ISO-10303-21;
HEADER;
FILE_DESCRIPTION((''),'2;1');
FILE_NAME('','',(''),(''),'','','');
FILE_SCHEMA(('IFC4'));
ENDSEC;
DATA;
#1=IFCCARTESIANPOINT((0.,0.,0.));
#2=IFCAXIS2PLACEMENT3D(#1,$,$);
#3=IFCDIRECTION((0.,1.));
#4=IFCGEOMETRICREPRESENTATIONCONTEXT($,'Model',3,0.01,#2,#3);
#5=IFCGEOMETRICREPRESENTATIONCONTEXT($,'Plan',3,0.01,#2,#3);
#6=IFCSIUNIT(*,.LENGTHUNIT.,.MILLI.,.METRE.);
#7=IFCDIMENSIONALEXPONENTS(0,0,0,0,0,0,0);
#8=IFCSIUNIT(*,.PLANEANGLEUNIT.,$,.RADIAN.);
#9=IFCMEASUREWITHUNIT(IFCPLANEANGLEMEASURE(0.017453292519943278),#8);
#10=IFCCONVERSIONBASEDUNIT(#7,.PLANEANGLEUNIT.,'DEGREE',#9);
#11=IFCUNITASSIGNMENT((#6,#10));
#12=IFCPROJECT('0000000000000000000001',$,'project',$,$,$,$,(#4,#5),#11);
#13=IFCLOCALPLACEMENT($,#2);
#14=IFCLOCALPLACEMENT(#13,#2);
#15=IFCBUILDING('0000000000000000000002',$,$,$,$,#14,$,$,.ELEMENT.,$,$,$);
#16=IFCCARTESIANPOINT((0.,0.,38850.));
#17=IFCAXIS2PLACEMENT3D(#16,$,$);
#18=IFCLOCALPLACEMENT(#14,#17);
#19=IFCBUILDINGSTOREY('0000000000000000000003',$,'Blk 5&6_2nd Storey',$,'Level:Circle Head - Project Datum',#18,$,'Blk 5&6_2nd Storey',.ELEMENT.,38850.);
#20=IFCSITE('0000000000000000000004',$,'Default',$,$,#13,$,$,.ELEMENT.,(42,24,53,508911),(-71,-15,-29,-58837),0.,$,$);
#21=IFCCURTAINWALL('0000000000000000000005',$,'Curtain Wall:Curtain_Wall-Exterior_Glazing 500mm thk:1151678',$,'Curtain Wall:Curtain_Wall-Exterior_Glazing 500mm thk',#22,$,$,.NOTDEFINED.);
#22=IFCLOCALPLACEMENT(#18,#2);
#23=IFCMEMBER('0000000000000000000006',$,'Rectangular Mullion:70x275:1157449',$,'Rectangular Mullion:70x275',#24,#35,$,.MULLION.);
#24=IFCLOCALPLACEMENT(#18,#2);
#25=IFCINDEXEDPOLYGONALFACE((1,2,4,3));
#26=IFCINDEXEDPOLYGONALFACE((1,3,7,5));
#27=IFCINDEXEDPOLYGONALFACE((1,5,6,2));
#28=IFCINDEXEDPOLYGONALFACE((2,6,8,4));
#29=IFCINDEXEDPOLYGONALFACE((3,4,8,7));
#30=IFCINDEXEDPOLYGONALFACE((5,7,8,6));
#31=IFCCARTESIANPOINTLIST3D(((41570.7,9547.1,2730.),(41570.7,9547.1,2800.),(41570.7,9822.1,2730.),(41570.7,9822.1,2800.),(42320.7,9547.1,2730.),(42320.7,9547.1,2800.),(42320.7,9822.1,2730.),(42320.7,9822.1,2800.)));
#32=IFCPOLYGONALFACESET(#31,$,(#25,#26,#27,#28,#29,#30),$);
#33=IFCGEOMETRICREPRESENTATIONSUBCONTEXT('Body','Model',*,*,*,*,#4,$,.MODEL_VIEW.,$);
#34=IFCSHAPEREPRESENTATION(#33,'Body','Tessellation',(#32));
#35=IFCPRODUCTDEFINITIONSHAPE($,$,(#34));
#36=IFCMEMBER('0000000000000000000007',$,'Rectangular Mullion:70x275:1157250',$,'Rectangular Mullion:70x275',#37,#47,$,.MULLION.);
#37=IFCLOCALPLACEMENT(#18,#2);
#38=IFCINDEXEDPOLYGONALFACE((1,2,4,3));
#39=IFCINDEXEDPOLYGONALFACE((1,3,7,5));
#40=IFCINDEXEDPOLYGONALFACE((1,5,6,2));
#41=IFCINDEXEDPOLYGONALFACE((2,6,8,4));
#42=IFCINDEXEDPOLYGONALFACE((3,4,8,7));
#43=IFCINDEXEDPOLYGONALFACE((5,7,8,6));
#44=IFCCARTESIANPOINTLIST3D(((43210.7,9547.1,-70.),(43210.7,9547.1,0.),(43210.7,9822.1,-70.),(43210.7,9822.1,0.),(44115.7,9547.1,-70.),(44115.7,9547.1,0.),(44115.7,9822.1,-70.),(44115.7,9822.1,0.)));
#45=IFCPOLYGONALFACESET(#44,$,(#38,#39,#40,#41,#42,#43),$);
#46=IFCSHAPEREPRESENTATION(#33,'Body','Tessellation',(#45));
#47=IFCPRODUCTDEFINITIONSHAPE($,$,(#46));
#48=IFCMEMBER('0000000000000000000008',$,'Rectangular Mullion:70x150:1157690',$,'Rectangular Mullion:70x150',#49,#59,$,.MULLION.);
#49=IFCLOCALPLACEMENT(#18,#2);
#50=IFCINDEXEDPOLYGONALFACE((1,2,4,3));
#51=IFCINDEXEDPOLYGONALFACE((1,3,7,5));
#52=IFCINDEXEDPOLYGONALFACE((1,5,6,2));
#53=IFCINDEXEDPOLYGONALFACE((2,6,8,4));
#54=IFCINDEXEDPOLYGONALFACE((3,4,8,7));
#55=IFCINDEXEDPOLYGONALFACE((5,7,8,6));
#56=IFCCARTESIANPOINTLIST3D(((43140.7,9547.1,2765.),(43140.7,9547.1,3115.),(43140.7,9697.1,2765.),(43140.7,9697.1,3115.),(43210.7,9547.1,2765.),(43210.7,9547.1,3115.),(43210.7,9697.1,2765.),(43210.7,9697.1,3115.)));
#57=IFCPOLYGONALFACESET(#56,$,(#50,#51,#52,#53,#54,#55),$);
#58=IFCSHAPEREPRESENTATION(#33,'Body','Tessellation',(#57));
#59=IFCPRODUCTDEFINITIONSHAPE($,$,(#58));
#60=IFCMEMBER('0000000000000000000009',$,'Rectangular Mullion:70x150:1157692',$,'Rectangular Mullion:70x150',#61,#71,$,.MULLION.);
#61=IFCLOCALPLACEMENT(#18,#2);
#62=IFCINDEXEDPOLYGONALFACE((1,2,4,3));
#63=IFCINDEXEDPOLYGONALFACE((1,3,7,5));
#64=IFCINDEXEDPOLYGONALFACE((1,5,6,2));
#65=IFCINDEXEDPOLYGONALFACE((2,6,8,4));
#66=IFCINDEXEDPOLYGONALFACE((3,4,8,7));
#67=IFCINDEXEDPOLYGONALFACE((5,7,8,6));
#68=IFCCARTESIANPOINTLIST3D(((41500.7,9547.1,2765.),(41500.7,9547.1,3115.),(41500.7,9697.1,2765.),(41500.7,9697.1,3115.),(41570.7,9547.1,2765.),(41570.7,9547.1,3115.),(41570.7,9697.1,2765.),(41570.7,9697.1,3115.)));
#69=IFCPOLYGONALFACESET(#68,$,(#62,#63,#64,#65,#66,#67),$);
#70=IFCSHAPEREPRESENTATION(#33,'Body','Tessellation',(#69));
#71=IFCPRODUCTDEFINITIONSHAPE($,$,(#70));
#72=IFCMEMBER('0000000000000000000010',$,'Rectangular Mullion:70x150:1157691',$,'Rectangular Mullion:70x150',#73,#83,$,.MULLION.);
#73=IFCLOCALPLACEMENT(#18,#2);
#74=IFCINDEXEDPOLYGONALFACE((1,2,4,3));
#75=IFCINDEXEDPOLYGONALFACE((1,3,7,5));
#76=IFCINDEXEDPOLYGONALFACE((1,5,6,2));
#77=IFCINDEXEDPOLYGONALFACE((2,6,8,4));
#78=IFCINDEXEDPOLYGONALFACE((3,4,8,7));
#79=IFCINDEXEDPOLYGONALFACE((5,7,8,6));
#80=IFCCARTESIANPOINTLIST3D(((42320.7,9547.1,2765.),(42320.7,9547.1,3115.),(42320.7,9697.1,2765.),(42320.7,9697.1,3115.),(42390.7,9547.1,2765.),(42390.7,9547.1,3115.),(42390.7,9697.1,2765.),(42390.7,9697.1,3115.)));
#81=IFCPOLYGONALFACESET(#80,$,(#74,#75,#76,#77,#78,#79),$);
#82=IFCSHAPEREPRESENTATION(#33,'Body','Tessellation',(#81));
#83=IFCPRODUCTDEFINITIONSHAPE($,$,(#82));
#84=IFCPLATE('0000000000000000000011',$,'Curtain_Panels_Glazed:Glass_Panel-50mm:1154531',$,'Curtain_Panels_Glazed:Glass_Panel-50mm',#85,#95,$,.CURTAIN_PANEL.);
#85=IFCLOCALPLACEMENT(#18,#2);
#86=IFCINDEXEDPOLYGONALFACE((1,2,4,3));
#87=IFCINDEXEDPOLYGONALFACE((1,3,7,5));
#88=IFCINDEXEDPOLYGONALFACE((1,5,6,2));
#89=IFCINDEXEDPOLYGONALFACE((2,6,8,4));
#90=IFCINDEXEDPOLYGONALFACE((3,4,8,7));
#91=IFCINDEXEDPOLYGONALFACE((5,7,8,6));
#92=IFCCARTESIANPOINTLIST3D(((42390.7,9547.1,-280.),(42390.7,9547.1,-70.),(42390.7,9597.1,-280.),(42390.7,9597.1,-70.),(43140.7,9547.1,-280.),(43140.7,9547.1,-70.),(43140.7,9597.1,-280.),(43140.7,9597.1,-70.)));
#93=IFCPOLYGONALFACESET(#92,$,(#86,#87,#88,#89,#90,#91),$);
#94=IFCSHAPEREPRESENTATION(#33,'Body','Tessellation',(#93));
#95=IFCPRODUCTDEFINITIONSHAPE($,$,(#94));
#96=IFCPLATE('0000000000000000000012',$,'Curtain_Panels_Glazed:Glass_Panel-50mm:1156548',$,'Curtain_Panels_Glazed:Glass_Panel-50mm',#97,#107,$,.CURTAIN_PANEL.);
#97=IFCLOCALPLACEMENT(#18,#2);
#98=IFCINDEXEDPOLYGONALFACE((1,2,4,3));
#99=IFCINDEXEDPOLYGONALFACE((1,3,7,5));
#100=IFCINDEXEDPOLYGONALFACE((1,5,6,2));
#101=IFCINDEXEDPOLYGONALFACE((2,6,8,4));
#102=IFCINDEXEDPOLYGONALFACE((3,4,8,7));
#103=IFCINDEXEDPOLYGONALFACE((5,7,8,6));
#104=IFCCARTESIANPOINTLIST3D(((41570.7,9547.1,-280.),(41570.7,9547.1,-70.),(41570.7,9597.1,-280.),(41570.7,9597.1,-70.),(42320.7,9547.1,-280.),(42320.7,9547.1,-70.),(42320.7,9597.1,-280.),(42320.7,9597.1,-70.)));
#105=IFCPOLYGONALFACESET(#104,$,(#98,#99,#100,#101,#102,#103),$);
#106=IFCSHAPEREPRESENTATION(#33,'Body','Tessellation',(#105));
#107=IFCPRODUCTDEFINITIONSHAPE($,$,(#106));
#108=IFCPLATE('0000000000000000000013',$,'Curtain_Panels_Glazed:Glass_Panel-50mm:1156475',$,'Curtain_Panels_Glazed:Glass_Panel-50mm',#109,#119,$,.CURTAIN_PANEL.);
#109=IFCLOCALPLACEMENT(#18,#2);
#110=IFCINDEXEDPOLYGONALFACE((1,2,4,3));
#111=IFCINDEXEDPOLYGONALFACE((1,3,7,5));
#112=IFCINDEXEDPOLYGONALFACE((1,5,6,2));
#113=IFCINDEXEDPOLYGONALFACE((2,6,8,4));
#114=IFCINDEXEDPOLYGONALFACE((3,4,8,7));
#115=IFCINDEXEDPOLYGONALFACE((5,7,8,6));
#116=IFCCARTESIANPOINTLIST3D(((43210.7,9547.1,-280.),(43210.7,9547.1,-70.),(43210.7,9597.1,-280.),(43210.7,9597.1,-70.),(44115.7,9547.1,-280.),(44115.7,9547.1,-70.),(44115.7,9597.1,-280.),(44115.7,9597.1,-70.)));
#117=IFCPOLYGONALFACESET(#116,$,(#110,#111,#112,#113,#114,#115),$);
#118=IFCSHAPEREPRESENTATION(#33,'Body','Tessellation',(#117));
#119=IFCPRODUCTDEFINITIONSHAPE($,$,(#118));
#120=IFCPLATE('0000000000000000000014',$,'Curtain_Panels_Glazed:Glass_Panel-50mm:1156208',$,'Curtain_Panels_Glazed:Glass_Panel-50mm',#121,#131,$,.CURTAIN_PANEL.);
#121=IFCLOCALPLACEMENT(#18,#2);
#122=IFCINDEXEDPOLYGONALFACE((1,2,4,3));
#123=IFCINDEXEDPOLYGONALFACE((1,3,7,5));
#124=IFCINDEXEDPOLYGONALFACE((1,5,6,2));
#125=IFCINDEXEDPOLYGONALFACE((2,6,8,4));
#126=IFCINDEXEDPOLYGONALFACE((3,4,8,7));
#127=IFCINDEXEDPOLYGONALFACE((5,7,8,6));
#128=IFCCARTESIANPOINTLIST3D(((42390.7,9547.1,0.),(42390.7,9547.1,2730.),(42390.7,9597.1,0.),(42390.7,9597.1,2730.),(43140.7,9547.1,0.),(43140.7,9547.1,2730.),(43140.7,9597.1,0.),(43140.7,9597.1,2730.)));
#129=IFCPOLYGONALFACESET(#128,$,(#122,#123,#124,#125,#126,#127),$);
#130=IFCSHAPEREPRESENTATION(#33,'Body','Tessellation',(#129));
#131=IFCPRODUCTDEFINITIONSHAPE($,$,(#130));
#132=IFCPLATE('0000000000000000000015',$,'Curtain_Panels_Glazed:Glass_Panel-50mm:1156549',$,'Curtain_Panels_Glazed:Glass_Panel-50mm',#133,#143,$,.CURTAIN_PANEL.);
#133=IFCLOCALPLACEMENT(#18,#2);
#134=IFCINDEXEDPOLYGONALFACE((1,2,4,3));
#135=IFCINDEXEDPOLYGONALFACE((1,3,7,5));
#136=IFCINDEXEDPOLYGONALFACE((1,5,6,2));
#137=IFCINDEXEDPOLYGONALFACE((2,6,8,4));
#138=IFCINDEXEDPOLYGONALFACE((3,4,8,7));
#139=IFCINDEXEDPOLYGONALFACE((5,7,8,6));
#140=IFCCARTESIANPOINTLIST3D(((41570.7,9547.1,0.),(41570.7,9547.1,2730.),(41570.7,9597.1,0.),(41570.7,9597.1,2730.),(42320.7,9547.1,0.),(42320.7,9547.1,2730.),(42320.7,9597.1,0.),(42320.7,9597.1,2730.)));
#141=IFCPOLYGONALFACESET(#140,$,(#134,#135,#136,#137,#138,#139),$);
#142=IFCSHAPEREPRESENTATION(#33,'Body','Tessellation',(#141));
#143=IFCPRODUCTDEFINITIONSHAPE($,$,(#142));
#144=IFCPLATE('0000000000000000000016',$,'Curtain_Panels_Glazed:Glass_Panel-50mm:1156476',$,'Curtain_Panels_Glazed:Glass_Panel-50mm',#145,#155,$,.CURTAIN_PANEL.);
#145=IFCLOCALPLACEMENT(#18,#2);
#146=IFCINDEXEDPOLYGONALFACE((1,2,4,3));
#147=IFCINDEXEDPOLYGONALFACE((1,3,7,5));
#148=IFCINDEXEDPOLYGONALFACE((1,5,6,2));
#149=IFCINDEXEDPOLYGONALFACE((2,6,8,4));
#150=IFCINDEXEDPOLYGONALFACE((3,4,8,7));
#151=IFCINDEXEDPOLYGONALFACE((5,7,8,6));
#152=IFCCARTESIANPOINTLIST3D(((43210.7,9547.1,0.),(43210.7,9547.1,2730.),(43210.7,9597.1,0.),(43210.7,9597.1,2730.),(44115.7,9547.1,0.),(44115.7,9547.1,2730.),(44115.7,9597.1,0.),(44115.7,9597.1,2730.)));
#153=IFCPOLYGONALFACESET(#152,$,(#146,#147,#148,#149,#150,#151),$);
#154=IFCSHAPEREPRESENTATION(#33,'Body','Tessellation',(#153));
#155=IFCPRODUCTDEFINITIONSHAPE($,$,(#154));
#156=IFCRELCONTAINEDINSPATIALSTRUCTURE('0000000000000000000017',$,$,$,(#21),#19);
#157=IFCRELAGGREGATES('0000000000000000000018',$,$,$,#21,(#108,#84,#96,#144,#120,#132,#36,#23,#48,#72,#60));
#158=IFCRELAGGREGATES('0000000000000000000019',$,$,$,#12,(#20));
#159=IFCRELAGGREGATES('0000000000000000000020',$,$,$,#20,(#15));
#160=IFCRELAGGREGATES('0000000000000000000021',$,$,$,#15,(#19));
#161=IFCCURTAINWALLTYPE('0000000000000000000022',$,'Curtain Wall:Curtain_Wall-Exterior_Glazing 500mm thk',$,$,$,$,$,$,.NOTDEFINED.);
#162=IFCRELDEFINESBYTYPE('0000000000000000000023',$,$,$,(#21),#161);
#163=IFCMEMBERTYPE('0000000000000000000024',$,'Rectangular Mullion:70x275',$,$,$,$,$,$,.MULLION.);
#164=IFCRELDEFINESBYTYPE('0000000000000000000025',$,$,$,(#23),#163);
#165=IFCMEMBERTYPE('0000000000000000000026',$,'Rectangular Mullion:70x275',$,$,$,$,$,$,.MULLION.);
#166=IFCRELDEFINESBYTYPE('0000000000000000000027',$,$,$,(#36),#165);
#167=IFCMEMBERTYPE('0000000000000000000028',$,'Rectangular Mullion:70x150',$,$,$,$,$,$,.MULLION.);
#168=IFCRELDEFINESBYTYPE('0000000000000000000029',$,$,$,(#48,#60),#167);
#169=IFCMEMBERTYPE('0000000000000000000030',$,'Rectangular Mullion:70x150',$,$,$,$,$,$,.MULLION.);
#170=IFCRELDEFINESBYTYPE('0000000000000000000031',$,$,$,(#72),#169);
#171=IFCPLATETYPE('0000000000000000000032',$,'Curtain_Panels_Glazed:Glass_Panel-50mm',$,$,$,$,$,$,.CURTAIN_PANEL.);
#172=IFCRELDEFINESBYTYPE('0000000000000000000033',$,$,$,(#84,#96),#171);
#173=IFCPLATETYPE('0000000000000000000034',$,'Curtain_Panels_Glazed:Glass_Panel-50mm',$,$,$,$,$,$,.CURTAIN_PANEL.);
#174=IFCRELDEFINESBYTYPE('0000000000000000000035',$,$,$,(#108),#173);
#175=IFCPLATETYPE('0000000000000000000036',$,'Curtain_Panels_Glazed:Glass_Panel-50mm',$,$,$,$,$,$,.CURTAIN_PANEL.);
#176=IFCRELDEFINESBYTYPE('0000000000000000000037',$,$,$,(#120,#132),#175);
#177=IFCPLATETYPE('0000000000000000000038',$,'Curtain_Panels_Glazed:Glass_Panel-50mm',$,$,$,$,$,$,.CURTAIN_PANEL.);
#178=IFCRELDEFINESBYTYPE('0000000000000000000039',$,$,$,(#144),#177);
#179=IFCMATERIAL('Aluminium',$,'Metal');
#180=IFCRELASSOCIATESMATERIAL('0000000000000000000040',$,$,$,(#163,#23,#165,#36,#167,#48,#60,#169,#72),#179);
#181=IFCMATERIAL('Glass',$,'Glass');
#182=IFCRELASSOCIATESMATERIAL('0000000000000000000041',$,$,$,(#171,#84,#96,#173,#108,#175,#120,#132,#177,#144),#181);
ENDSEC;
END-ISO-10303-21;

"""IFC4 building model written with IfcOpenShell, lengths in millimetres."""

from ifc_helpers import new_model, entity, si_unit, converted_unit, direction, frame, origin, place, context, subcontext, project, spatial, indexed_curve, outline, extrude, source, transform, mapped, material, type_object, type_shapes, element, aggregate, save


model = new_model("IFC4")

# Units and contexts
model_context = context("Model", 3, precision=0.01, world=origin(), true_north=direction((0.0, 1.0)))
plan_context = context("Plan", 3, precision=0.01, world=origin(), true_north=direction((0.0, 1.0)))
body_context = subcontext(model_context, "Body", "Model", "MODEL_VIEW")
ifc_project = project(units=[si_unit("LENGTHUNIT", "METRE", prefix="MILLI"), converted_unit("PLANEANGLEUNIT", "DEGREE", entity("IfcPlaneAngleMeasure", 0.017453292519943278), si_unit("PLANEANGLEUNIT", "RADIAN"), dimensions=[0, 0, 0, 0, 0, 0, 0])], contexts=[model_context, plan_context])

# Site, building, storey
site_placement = place(None, origin())
site = spatial("IfcSite", under=ifc_project, at=site_placement, Name="Default", CompositionType="ELEMENT", RefLatitude=(42, 24, 53, 508911), RefLongitude=(-71, -15, -29, -58837), RefElevation=0.0)
building_placement = place(site_placement, origin())
building = spatial("IfcBuilding", under=site, at=building_placement, CompositionType="ELEMENT")
storey_placement = place(building_placement, frame((0.0, 0.0, 38850.0)))
storey = spatial("IfcBuildingStorey", under=building, at=storey_placement, Name="Blk 5&6_2nd Storey", ObjectType="Level:Circle Head - Project Datum", LongName="Blk 5&6_2nd Storey", CompositionType="ELEMENT", Elevation=38850.0)

# Curtain wall, members, plates
curtain_wall_type = type_object("IfcCurtainWallType", Name="Curtain Wall:Curtain_Wall-Exterior_Glazing 500mm thk", PredefinedType="NOTDEFINED")
curtain_wall_placement = place(storey_placement, frame((0.0, 0.0, -38850.0)))
curtain_wall = element("IfcCurtainWall", 1, at=curtain_wall_placement, inside=storey, type_object=curtain_wall_type, Name="Curtain Wall:Curtain_Wall-Exterior_Glazing 500mm thk:1151678", ObjectType="Curtain Wall:Curtain_Wall-Exterior_Glazing 500mm thk", PredefinedType="NOTDEFINED")
ifc_material_1 = material(Name="Aluminium", Category="Metal")
member_type_1 = type_object("IfcMemberType", Name="Rectangular Mullion:70x275", PredefinedType="MULLION", material=ifc_material_1)
shared_shape_1 = source(origin(), body_context, "Body", "SweptSolid", [
    extrude(outline(indexed_curve([(-35.0, -137.5), (35.0, -137.5), (35.0, 137.5), (-35.0, 137.5), (-35.0, -137.5)], self_intersect=False)), frame((0.0, -137.5, -750.0), z_axis=(0.0, 0.0, 1.0), x_axis=(-1.0, 0.0, 0.0)), (0.0, 0.0, 1.0), 750.0),
])
type_shapes(member_type_1, [shared_shape_1])
member_1_placement = place(curtain_wall_placement, frame((41570.7, 9822.1, 41615.0), z_axis=(-1.0, 0.0, 0.0), x_axis=(0.0, 0.0, 1.0)))
member_1 = element("IfcMember", 2, at=member_1_placement, type_object=member_type_1, material=ifc_material_1, Name="Rectangular Mullion:70x275:1157449", ObjectType="Rectangular Mullion:70x275", PredefinedType="MULLION", context=body_context, shape_type="MappedRepresentation", body=[
    mapped(shared_shape_1, transform((0.0, 0.0, 0.0), scale=1.0)),
])
member_type_2 = type_object("IfcMemberType", Name="Rectangular Mullion:70x275", PredefinedType="MULLION", material=ifc_material_1)
shared_shape_2 = source(origin(), body_context, "Body", "SweptSolid", [
    extrude(outline(indexed_curve([(-35.0, -137.5), (35.0, -137.5), (35.0, 137.5), (-35.0, 137.5), (-35.0, -137.5)], self_intersect=False)), frame((0.0, -137.5, -905.0), z_axis=(0.0, 0.0, 1.0), x_axis=(-1.0, 0.0, 0.0)), (0.0, 0.0, 1.0), 905.0),
])
type_shapes(member_type_2, [shared_shape_2])
member_2_placement = place(curtain_wall_placement, frame((43210.7, 9822.1, 38815.0), z_axis=(-1.0, 0.0, 0.0), x_axis=(0.0, 0.0, 1.0)))
member_2 = element("IfcMember", 3, at=member_2_placement, type_object=member_type_2, material=ifc_material_1, Name="Rectangular Mullion:70x275:1157250", ObjectType="Rectangular Mullion:70x275", PredefinedType="MULLION", context=body_context, shape_type="MappedRepresentation", body=[
    mapped(shared_shape_2, transform((0.0, 0.0, 0.0), scale=1.0)),
])
member_type_3 = type_object("IfcMemberType", Name="Rectangular Mullion:70x150", PredefinedType="MULLION", material=ifc_material_1)
shared_shape_3 = source(origin(), body_context, "Body", "SweptSolid", [
    extrude(outline(indexed_curve([(-35.0, -75.0), (35.0, -75.0), (35.0, 75.0), (-35.0, 75.0), (-35.0, -75.0)], self_intersect=False)), frame((0.0, -200.0, -350.0), z_axis=(0.0, 0.0, 1.0), x_axis=(-1.0, 0.0, 0.0)), (0.0, 0.0, 1.0), 350.0),
])
type_shapes(member_type_3, [shared_shape_3])
member_3_placement = place(curtain_wall_placement, frame((43175.7, 9822.1, 41615.0), z_axis=(0.0, 0.0, -1.0), x_axis=(-1.0, 0.0, 0.0)))
member_3 = element("IfcMember", 4, at=member_3_placement, type_object=member_type_3, material=ifc_material_1, Name="Rectangular Mullion:70x150:1157690", ObjectType="Rectangular Mullion:70x150", PredefinedType="MULLION", context=body_context, shape_type="MappedRepresentation", body=[
    mapped(shared_shape_3, transform((0.0, 0.0, 0.0), scale=1.0)),
])
member_4_placement = place(curtain_wall_placement, frame((41535.7, 9822.1, 41615.0), z_axis=(0.0, 0.0, -1.0), x_axis=(-1.0, 0.0, 0.0)))
member_4 = element("IfcMember", 5, at=member_4_placement, type_object=member_type_3, material=ifc_material_1, Name="Rectangular Mullion:70x150:1157692", ObjectType="Rectangular Mullion:70x150", PredefinedType="MULLION", context=body_context, shape_type="MappedRepresentation", body=[
    mapped(shared_shape_3, transform((0.0, 0.0, 0.0), scale=1.0)),
])
member_type_4 = type_object("IfcMemberType", Name="Rectangular Mullion:70x150", PredefinedType="MULLION", material=ifc_material_1)
shared_shape_4 = source(origin(), body_context, "Body", "SweptSolid", [
    extrude(outline(indexed_curve([(-35.0, -75.0), (35.0, -75.0), (35.0, 75.0), (-35.0, 75.0), (-35.0, -75.0)], self_intersect=False)), frame((0.0, -200.0, -350.0), z_axis=(0.0, 0.0, 1.0), x_axis=(-1.0, 0.0, 0.0)), (0.0, 0.0, 1.0), 350.0),
])
type_shapes(member_type_4, [shared_shape_4])
member_5_placement = place(curtain_wall_placement, frame((42355.7, 9822.1, 41615.0), z_axis=(0.0, 0.0, -1.0), x_axis=(-1.0, 0.0, 0.0)))
member_5 = element("IfcMember", 6, at=member_5_placement, type_object=member_type_4, material=ifc_material_1, Name="Rectangular Mullion:70x150:1157691", ObjectType="Rectangular Mullion:70x150", PredefinedType="MULLION", context=body_context, shape_type="MappedRepresentation", body=[
    mapped(shared_shape_4, transform((0.0, 0.0, 0.0), scale=1.0)),
])
ifc_material_2 = material(Name="Glass", Category="Glass")
plate_type_1 = type_object("IfcPlateType", Name="Curtain_Panels_Glazed:Glass_Panel-50mm", PredefinedType="CURTAIN_PANEL", material=ifc_material_2)
shared_shape_5 = source(origin(), body_context, "Body", "SweptSolid", [
    extrude(outline(indexed_curve([(-25.0, -375.0), (25.0, -375.0), (25.0, 375.0), (-25.0, 375.0), (-25.0, -375.0)], self_intersect=False)), frame((0.0, 250.0, 0.0), z_axis=(0.0, 0.0, 1.0), x_axis=(0.0, 1.0, 0.0)), (0.0, 0.0, 1.0), 210.0),
])
type_shapes(plate_type_1, [shared_shape_5])
plate_1_placement = place(curtain_wall_placement, frame((42765.7, 9822.1, 38570.0), z_axis=(0.0, 0.0, 1.0), x_axis=(-1.0, 0.0, 0.0)))
plate_1 = element("IfcPlate", 7, at=plate_1_placement, type_object=plate_type_1, material=ifc_material_2, Name="Curtain_Panels_Glazed:Glass_Panel-50mm:1154531", ObjectType="Curtain_Panels_Glazed:Glass_Panel-50mm", PredefinedType="CURTAIN_PANEL", context=body_context, shape_type="MappedRepresentation", body=[
    mapped(shared_shape_5, transform((0.0, 0.0, 0.0), scale=1.0)),
])
plate_2_placement = place(curtain_wall_placement, frame((41945.7, 9822.1, 38570.0), z_axis=(0.0, 0.0, 1.0), x_axis=(-1.0, 0.0, 0.0)))
plate_2 = element("IfcPlate", 8, at=plate_2_placement, type_object=plate_type_1, material=ifc_material_2, Name="Curtain_Panels_Glazed:Glass_Panel-50mm:1156548", ObjectType="Curtain_Panels_Glazed:Glass_Panel-50mm", PredefinedType="CURTAIN_PANEL", context=body_context, shape_type="MappedRepresentation", body=[
    mapped(shared_shape_5, transform((0.0, 0.0, 0.0), scale=1.0)),
])
plate_type_2 = type_object("IfcPlateType", Name="Curtain_Panels_Glazed:Glass_Panel-50mm", PredefinedType="CURTAIN_PANEL", material=ifc_material_2)
shared_shape_6 = source(origin(), body_context, "Body", "SweptSolid", [
    extrude(outline(indexed_curve([(-25.0, -452.5), (25.0, -452.5), (25.0, 452.5), (-25.0, 452.5), (-25.0, -452.5)], self_intersect=False)), frame((0.0, 250.0, 0.0), z_axis=(0.0, 0.0, 1.0), x_axis=(0.0, 1.0, 0.0)), (0.0, 0.0, 1.0), 210.0),
])
type_shapes(plate_type_2, [shared_shape_6])
plate_3_placement = place(curtain_wall_placement, frame((43663.2, 9822.1, 38570.0), z_axis=(0.0, 0.0, 1.0), x_axis=(-1.0, 0.0, 0.0)))
plate_3 = element("IfcPlate", 9, at=plate_3_placement, type_object=plate_type_2, material=ifc_material_2, Name="Curtain_Panels_Glazed:Glass_Panel-50mm:1156475", ObjectType="Curtain_Panels_Glazed:Glass_Panel-50mm", PredefinedType="CURTAIN_PANEL", context=body_context, shape_type="MappedRepresentation", body=[
    mapped(shared_shape_6, transform((0.0, 0.0, 0.0), scale=1.0)),
])
plate_type_3 = type_object("IfcPlateType", Name="Curtain_Panels_Glazed:Glass_Panel-50mm", PredefinedType="CURTAIN_PANEL", material=ifc_material_2)
shared_shape_7 = source(origin(), body_context, "Body", "SweptSolid", [
    extrude(outline(indexed_curve([(-25.0, -375.0), (25.0, -375.0), (25.0, 375.0), (-25.0, 375.0), (-25.0, -375.0)], self_intersect=False)), frame((0.0, 250.0, 0.0), z_axis=(0.0, 0.0, 1.0), x_axis=(0.0, 1.0, 0.0)), (0.0, 0.0, 1.0), 2730.0),
])
type_shapes(plate_type_3, [shared_shape_7])
plate_4_placement = place(curtain_wall_placement, frame((42765.7, 9822.1, 38850.0), z_axis=(0.0, 0.0, 1.0), x_axis=(-1.0, 0.0, 0.0)))
plate_4 = element("IfcPlate", 10, at=plate_4_placement, type_object=plate_type_3, material=ifc_material_2, Name="Curtain_Panels_Glazed:Glass_Panel-50mm:1156208", ObjectType="Curtain_Panels_Glazed:Glass_Panel-50mm", PredefinedType="CURTAIN_PANEL", context=body_context, shape_type="MappedRepresentation", body=[
    mapped(shared_shape_7, transform((0.0, 0.0, 0.0), scale=1.0)),
])
plate_5_placement = place(curtain_wall_placement, frame((41945.7, 9822.1, 38850.0), z_axis=(0.0, 0.0, 1.0), x_axis=(-1.0, 0.0, 0.0)))
plate_5 = element("IfcPlate", 11, at=plate_5_placement, type_object=plate_type_3, material=ifc_material_2, Name="Curtain_Panels_Glazed:Glass_Panel-50mm:1156549", ObjectType="Curtain_Panels_Glazed:Glass_Panel-50mm", PredefinedType="CURTAIN_PANEL", context=body_context, shape_type="MappedRepresentation", body=[
    mapped(shared_shape_7, transform((0.0, 0.0, 0.0), scale=1.0)),
])
plate_type_4 = type_object("IfcPlateType", Name="Curtain_Panels_Glazed:Glass_Panel-50mm", PredefinedType="CURTAIN_PANEL", material=ifc_material_2)
shared_shape_8 = source(origin(), body_context, "Body", "SweptSolid", [
    extrude(outline(indexed_curve([(-25.0, -452.5), (25.0, -452.5), (25.0, 452.5), (-25.0, 452.5), (-25.0, -452.5)], self_intersect=False)), frame((0.0, 250.0, 0.0), z_axis=(0.0, 0.0, 1.0), x_axis=(0.0, 1.0, 0.0)), (0.0, 0.0, 1.0), 2730.0),
])
type_shapes(plate_type_4, [shared_shape_8])
plate_6_placement = place(curtain_wall_placement, frame((43663.2, 9822.1, 38850.0), z_axis=(0.0, 0.0, 1.0), x_axis=(-1.0, 0.0, 0.0)))
plate_6 = element("IfcPlate", 12, at=plate_6_placement, type_object=plate_type_4, material=ifc_material_2, Name="Curtain_Panels_Glazed:Glass_Panel-50mm:1156476", ObjectType="Curtain_Panels_Glazed:Glass_Panel-50mm", PredefinedType="CURTAIN_PANEL", context=body_context, shape_type="MappedRepresentation", body=[
    mapped(shared_shape_8, transform((0.0, 0.0, 0.0), scale=1.0)),
])
aggregate(curtain_wall, [plate_3, plate_1, plate_2, plate_6, plate_4, plate_5, member_2, member_1, member_3, member_5, member_4])

save(model, "model.ifc")
